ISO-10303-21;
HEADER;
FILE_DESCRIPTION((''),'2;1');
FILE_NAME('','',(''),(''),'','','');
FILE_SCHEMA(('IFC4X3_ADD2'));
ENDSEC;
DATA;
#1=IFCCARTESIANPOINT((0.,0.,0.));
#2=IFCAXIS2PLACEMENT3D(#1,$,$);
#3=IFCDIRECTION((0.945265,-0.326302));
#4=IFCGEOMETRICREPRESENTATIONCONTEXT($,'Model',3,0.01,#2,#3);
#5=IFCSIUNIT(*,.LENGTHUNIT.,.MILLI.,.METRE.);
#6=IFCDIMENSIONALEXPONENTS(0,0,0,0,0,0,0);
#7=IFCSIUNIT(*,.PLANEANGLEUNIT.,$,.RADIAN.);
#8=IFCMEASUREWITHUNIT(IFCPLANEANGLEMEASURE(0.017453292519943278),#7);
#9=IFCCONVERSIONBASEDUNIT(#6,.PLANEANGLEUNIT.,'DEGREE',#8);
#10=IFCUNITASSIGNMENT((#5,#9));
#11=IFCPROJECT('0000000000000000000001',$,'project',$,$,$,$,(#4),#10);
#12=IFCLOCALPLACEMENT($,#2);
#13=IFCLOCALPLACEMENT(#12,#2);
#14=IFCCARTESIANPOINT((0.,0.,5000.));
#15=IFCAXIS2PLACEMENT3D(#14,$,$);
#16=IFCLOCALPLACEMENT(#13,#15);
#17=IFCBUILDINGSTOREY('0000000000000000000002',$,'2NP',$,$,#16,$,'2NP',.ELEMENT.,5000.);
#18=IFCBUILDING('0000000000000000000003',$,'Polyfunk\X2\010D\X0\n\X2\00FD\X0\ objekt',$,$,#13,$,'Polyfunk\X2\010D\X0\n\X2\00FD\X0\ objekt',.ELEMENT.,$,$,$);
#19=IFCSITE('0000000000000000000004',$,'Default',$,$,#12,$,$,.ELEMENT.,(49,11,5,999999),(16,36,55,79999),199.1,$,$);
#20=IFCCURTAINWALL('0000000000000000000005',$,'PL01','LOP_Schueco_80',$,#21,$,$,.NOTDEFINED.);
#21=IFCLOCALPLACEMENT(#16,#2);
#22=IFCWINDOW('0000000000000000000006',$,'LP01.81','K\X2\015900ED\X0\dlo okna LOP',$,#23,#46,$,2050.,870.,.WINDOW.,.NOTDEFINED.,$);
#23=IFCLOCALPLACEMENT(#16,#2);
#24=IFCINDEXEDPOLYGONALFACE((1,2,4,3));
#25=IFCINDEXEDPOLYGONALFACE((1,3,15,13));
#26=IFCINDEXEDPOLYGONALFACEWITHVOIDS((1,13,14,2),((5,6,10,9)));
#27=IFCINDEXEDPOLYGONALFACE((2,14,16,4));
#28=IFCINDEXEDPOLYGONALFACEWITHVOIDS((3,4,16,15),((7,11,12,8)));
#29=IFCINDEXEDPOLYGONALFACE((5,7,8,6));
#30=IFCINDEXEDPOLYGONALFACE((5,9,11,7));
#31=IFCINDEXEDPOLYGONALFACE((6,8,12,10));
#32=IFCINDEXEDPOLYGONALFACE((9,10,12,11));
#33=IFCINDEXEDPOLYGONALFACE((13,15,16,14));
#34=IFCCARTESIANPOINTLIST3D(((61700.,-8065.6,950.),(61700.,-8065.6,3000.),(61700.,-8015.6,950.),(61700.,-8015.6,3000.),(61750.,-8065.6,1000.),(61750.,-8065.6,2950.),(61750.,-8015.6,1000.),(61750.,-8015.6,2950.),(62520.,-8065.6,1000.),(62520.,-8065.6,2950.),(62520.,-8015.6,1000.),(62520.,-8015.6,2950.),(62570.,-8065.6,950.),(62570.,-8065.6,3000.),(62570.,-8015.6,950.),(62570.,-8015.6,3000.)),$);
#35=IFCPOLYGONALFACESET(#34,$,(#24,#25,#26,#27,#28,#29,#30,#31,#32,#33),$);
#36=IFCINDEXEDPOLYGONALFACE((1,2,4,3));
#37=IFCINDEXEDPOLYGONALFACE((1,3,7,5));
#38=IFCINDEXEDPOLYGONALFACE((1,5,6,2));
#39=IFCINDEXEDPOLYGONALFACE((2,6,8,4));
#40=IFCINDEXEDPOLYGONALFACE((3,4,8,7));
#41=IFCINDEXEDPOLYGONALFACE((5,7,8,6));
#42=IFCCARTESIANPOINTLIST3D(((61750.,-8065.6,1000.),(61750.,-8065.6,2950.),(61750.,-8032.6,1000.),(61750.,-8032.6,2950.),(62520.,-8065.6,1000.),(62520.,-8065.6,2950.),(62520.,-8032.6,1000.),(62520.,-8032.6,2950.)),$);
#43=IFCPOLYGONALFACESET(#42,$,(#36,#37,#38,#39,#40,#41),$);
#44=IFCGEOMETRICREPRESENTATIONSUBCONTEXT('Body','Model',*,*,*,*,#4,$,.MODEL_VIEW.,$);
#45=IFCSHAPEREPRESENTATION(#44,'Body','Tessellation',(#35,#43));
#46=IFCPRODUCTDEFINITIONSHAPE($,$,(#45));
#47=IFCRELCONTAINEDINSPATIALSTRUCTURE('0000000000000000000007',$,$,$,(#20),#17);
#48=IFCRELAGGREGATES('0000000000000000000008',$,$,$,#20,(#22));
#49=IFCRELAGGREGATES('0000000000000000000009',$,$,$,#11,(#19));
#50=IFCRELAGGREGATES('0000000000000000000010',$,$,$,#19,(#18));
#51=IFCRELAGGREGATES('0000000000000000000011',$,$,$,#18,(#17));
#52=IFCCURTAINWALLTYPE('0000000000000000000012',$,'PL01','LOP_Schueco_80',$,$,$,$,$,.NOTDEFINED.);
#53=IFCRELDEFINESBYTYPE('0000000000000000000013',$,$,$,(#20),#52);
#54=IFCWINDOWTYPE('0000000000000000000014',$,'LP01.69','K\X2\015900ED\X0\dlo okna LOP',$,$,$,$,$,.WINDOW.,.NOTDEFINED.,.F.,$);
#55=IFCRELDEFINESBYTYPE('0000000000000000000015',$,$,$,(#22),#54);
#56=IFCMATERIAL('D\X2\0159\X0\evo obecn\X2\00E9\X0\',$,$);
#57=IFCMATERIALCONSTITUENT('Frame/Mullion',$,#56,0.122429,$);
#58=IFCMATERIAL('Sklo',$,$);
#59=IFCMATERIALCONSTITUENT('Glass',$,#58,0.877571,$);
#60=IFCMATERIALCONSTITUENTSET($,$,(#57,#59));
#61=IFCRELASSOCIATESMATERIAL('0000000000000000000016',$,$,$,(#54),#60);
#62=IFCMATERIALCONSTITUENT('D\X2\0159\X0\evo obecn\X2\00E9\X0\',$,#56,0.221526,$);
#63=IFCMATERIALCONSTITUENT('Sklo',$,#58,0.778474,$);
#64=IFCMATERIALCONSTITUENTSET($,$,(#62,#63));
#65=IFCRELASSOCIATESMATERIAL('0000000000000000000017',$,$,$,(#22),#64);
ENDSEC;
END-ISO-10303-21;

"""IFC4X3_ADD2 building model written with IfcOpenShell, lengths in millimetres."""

from ifc_helpers import new_model, entity, si_unit, converted_unit, direction, frame, frame_2d, origin, place, context, subcontext, project, spatial, polyline, rectangle, outline, extrude, source, transform, mapped, material, constituent, constituent_set, type_object, type_shapes, element, aggregate, save


model = new_model("IFC4X3_ADD2")

# Units and contexts
model_context = context("Model", 3, precision=0.01, world=origin(), true_north=direction((0.945265, -0.326302)))
body_context = subcontext(model_context, "Body", "Model", "MODEL_VIEW")
ifc_project = project(units=[si_unit("LENGTHUNIT", "METRE", prefix="MILLI"), converted_unit("PLANEANGLEUNIT", "DEGREE", entity("IfcPlaneAngleMeasure", 0.017453292519943278), si_unit("PLANEANGLEUNIT", "RADIAN"), dimensions=[0, 0, 0, 0, 0, 0, 0])], contexts=[model_context])

# Site, building, storey
site_placement = place(None, origin())
site = spatial("IfcSite", under=ifc_project, at=site_placement, Name="Default", CompositionType="ELEMENT", RefLatitude=(49, 11, 5, 999999), RefLongitude=(16, 36, 55, 79999), RefElevation=199.1)
building_placement = place(site_placement, origin())
building = spatial("IfcBuilding", under=site, at=building_placement, Name="Polyfunkčný objekt", LongName="Polyfunkčný objekt", CompositionType="ELEMENT")
storey_placement = place(building_placement, frame((0.0, 0.0, 5000.0)))
storey = spatial("IfcBuildingStorey", under=building, at=storey_placement, Name="2NP", LongName="2NP", CompositionType="ELEMENT", Elevation=5000.0)

# Curtain wall
curtain_wall_type = type_object("IfcCurtainWallType", Name="PL01", Description="LOP_Schueco_80", PredefinedType="NOTDEFINED")
curtain_wall_1_placement = place(storey_placement, frame((0.0, 0.0, -5000.0)))
curtain_wall_1 = element("IfcCurtainWall", 1, at=curtain_wall_1_placement, inside=storey, type_object=curtain_wall_type, Name="PL01", Description="LOP_Schueco_80", PredefinedType="NOTDEFINED")

# Shared definitions
ifc_material_1 = material(Name="Sklo")

# Window
ifc_material_2 = material(Name="Dřevo obecné")
ifc_constituent_1 = constituent(ifc_material_2, Name="Dřevo obecné", fraction=0.221526)
ifc_constituent_2 = constituent(ifc_material_1, Name="Sklo", fraction=0.778474)
ifc_constituent_set_1 = constituent_set(constituents=[ifc_constituent_1, ifc_constituent_2])
ifc_constituent_3 = constituent(ifc_material_2, Name="Frame/Mullion", fraction=0.122429)
ifc_constituent_4 = constituent(ifc_material_1, Name="Glass", fraction=0.877571)
ifc_constituent_set_2 = constituent_set(constituents=[ifc_constituent_3, ifc_constituent_4])
window_type_1 = type_object("IfcWindowType", Name="LP01.69", Description="Křídlo okna LOP", ParameterTakesPrecedence=False, PartitioningType="NOTDEFINED", PredefinedType="WINDOW", material=ifc_constituent_set_2)
shared_shape_1 = source(origin(), body_context, "Body", "SweptSolid", [
    extrude(outline(polyline([(-1025.0, -435.0), (1025.0, -435.0), (1025.0, 435.0), (-1025.0, 435.0), (-1025.0, -435.0)]), holes=[polyline([(-975.0, -385.0), (-975.0, 385.0), (975.0, 385.0), (975.0, -385.0), (-975.0, -385.0)])]), frame((0.0, 50.0, 1025.0), z_axis=(0.0, -1.0, 0.0), x_axis=(0.0, 0.0, -1.0)), (0.0, 0.0, 1.0), 50.0),
    extrude(rectangle(XDim=770.0, YDim=33.0, at=frame_2d((0.0, 0.0), x_axis=(1.0, 0.0))), frame((0.0, 33.5, 50.0), z_axis=(0.0, 0.0, 1.0), x_axis=(-1.0, 0.0, 0.0)), (0.0, 0.0, 1.0), 1950.0),
])
type_shapes(window_type_1, [shared_shape_1])
window_1_placement = place(curtain_wall_1_placement, frame((62135.0, -8015.6, 5950.0), z_axis=(0.0, 0.0, 1.0), x_axis=(-1.0, 0.0, 0.0)))
window_1 = element("IfcWindow", 2, at=window_1_placement, type_object=window_type_1, material=ifc_constituent_set_1, Name="LP01.81", Description="Křídlo okna LOP", OverallHeight=2050.0, OverallWidth=870.0, PartitioningType="NOTDEFINED", PredefinedType="WINDOW", context=body_context, shape_type="MappedRepresentation", body=[
    mapped(shared_shape_1, transform((0.0, 0.0, 0.0), scale=1.0)),
])
aggregate(curtain_wall_1, [window_1])

save(model, "model.ifc")
